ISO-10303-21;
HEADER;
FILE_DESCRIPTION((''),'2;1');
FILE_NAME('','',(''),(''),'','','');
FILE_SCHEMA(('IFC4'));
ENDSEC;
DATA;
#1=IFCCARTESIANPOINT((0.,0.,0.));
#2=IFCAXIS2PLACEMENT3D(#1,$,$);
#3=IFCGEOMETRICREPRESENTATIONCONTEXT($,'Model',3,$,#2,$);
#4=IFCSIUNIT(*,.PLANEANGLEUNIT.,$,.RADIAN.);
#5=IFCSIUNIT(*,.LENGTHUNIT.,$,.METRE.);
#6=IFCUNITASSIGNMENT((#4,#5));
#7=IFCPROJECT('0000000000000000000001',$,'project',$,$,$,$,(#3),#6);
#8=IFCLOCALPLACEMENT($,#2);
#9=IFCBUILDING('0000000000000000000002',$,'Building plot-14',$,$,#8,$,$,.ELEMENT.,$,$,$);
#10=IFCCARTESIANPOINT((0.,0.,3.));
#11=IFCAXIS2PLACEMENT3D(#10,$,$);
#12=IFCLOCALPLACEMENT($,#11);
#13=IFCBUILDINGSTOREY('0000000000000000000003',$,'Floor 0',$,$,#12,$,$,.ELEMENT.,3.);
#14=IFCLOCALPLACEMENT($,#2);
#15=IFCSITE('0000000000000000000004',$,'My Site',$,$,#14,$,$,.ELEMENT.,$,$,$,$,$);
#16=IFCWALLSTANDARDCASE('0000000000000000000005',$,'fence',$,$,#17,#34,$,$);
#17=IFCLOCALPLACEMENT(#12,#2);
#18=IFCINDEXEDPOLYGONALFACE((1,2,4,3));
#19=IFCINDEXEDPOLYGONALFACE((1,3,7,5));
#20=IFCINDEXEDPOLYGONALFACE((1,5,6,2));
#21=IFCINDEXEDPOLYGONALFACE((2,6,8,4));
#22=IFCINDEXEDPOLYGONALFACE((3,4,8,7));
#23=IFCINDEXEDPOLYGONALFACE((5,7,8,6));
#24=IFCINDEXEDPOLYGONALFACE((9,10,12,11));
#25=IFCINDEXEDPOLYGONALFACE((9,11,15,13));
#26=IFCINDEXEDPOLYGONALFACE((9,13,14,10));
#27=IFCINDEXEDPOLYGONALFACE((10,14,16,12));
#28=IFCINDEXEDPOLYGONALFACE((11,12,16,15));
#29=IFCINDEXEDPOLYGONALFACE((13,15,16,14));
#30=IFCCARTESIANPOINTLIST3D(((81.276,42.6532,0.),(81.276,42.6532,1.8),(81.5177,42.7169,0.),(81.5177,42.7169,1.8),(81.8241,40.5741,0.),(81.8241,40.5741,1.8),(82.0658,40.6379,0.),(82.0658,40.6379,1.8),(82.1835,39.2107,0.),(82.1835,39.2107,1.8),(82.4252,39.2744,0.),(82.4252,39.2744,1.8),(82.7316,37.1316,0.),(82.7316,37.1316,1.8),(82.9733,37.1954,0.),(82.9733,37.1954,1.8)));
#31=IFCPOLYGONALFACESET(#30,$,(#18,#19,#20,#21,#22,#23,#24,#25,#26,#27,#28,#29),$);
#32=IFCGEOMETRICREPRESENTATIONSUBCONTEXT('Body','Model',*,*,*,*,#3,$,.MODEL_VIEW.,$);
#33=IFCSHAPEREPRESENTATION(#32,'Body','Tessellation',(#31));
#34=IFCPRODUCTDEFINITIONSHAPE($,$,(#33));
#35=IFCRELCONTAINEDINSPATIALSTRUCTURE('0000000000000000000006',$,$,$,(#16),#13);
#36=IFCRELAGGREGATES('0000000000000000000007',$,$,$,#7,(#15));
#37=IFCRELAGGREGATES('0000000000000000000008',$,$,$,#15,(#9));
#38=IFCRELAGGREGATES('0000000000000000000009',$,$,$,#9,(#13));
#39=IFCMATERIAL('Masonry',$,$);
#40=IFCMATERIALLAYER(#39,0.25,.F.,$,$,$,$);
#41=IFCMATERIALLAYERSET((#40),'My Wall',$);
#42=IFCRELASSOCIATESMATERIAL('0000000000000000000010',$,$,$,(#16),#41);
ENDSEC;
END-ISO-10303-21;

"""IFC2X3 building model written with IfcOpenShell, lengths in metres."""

from ifc_helpers import new_model, si_unit, frame, origin, place, context, subcontext, project, spatial, polyline, outline, extrude, material, layer, layer_set, layer_usage, element, save


model = new_model("IFC2X3")

# Units and contexts
model_context = context("Model", 3, world=origin())
body_context = subcontext(model_context, "Body", "Model", "MODEL_VIEW")
ifc_project = project(units=[si_unit("PLANEANGLEUNIT", "RADIAN"), si_unit("LENGTHUNIT", "METRE")], contexts=[model_context])

# Site, building, storey
site_placement = place(None, origin())
site = spatial("IfcSite", under=ifc_project, at=site_placement, Name="My Site", CompositionType="ELEMENT")
building_placement = place(None, origin())
building = spatial("IfcBuilding", under=site, at=building_placement, Name="Building plot-14", CompositionType="ELEMENT")
storey_placement = place(None, frame((0.0, 0.0, 3.0)))
storey = spatial("IfcBuildingStorey", under=building, at=storey_placement, Name="Floor 0", CompositionType="ELEMENT", Elevation=3.0)

# Wall, opening
ifc_material_1 = material(Name="Masonry")
ifc_layer_1 = layer(ifc_material_1, 0.25, ventilated=False)
ifc_layer_set_1 = layer_set([ifc_layer_1], Name="My Wall")
ifc_layer_usage_1 = layer_usage(ifc_layer_set_1, "AXIS2", "NEGATIVE", 0.0)
wall_1_placement = place(storey_placement, origin())
wall_1 = element("IfcWallStandardCase", 1, at=wall_1_placement, inside=storey, material=ifc_layer_usage_1, Name="fence", context=body_context, shape_type="SweptSolid", body=[
    extrude(outline(polyline([(82.7316, 37.1316), (82.9733, 37.1954), (81.5177, 42.7169), (81.276, 42.6532), (82.7316, 37.1316)])), origin(), (0.0, 0.0, 1.0), 1.8),
])
opening_1_placement = place(storey_placement, origin())
element("IfcOpeningElement", 2, at=opening_1_placement, cuts=wall_1, ObjectType="Opening", context=body_context, shape_type="SweptSolid", body=[
    extrude(outline(polyline([(82.4252, 39.2744), (82.0658, 40.6379), (81.8241, 40.5741), (82.1835, 39.2107), (82.4252, 39.2744)])), origin(), (0.0, 0.0, 1.0), 2.08),
])

save(model, "model.ifc")
